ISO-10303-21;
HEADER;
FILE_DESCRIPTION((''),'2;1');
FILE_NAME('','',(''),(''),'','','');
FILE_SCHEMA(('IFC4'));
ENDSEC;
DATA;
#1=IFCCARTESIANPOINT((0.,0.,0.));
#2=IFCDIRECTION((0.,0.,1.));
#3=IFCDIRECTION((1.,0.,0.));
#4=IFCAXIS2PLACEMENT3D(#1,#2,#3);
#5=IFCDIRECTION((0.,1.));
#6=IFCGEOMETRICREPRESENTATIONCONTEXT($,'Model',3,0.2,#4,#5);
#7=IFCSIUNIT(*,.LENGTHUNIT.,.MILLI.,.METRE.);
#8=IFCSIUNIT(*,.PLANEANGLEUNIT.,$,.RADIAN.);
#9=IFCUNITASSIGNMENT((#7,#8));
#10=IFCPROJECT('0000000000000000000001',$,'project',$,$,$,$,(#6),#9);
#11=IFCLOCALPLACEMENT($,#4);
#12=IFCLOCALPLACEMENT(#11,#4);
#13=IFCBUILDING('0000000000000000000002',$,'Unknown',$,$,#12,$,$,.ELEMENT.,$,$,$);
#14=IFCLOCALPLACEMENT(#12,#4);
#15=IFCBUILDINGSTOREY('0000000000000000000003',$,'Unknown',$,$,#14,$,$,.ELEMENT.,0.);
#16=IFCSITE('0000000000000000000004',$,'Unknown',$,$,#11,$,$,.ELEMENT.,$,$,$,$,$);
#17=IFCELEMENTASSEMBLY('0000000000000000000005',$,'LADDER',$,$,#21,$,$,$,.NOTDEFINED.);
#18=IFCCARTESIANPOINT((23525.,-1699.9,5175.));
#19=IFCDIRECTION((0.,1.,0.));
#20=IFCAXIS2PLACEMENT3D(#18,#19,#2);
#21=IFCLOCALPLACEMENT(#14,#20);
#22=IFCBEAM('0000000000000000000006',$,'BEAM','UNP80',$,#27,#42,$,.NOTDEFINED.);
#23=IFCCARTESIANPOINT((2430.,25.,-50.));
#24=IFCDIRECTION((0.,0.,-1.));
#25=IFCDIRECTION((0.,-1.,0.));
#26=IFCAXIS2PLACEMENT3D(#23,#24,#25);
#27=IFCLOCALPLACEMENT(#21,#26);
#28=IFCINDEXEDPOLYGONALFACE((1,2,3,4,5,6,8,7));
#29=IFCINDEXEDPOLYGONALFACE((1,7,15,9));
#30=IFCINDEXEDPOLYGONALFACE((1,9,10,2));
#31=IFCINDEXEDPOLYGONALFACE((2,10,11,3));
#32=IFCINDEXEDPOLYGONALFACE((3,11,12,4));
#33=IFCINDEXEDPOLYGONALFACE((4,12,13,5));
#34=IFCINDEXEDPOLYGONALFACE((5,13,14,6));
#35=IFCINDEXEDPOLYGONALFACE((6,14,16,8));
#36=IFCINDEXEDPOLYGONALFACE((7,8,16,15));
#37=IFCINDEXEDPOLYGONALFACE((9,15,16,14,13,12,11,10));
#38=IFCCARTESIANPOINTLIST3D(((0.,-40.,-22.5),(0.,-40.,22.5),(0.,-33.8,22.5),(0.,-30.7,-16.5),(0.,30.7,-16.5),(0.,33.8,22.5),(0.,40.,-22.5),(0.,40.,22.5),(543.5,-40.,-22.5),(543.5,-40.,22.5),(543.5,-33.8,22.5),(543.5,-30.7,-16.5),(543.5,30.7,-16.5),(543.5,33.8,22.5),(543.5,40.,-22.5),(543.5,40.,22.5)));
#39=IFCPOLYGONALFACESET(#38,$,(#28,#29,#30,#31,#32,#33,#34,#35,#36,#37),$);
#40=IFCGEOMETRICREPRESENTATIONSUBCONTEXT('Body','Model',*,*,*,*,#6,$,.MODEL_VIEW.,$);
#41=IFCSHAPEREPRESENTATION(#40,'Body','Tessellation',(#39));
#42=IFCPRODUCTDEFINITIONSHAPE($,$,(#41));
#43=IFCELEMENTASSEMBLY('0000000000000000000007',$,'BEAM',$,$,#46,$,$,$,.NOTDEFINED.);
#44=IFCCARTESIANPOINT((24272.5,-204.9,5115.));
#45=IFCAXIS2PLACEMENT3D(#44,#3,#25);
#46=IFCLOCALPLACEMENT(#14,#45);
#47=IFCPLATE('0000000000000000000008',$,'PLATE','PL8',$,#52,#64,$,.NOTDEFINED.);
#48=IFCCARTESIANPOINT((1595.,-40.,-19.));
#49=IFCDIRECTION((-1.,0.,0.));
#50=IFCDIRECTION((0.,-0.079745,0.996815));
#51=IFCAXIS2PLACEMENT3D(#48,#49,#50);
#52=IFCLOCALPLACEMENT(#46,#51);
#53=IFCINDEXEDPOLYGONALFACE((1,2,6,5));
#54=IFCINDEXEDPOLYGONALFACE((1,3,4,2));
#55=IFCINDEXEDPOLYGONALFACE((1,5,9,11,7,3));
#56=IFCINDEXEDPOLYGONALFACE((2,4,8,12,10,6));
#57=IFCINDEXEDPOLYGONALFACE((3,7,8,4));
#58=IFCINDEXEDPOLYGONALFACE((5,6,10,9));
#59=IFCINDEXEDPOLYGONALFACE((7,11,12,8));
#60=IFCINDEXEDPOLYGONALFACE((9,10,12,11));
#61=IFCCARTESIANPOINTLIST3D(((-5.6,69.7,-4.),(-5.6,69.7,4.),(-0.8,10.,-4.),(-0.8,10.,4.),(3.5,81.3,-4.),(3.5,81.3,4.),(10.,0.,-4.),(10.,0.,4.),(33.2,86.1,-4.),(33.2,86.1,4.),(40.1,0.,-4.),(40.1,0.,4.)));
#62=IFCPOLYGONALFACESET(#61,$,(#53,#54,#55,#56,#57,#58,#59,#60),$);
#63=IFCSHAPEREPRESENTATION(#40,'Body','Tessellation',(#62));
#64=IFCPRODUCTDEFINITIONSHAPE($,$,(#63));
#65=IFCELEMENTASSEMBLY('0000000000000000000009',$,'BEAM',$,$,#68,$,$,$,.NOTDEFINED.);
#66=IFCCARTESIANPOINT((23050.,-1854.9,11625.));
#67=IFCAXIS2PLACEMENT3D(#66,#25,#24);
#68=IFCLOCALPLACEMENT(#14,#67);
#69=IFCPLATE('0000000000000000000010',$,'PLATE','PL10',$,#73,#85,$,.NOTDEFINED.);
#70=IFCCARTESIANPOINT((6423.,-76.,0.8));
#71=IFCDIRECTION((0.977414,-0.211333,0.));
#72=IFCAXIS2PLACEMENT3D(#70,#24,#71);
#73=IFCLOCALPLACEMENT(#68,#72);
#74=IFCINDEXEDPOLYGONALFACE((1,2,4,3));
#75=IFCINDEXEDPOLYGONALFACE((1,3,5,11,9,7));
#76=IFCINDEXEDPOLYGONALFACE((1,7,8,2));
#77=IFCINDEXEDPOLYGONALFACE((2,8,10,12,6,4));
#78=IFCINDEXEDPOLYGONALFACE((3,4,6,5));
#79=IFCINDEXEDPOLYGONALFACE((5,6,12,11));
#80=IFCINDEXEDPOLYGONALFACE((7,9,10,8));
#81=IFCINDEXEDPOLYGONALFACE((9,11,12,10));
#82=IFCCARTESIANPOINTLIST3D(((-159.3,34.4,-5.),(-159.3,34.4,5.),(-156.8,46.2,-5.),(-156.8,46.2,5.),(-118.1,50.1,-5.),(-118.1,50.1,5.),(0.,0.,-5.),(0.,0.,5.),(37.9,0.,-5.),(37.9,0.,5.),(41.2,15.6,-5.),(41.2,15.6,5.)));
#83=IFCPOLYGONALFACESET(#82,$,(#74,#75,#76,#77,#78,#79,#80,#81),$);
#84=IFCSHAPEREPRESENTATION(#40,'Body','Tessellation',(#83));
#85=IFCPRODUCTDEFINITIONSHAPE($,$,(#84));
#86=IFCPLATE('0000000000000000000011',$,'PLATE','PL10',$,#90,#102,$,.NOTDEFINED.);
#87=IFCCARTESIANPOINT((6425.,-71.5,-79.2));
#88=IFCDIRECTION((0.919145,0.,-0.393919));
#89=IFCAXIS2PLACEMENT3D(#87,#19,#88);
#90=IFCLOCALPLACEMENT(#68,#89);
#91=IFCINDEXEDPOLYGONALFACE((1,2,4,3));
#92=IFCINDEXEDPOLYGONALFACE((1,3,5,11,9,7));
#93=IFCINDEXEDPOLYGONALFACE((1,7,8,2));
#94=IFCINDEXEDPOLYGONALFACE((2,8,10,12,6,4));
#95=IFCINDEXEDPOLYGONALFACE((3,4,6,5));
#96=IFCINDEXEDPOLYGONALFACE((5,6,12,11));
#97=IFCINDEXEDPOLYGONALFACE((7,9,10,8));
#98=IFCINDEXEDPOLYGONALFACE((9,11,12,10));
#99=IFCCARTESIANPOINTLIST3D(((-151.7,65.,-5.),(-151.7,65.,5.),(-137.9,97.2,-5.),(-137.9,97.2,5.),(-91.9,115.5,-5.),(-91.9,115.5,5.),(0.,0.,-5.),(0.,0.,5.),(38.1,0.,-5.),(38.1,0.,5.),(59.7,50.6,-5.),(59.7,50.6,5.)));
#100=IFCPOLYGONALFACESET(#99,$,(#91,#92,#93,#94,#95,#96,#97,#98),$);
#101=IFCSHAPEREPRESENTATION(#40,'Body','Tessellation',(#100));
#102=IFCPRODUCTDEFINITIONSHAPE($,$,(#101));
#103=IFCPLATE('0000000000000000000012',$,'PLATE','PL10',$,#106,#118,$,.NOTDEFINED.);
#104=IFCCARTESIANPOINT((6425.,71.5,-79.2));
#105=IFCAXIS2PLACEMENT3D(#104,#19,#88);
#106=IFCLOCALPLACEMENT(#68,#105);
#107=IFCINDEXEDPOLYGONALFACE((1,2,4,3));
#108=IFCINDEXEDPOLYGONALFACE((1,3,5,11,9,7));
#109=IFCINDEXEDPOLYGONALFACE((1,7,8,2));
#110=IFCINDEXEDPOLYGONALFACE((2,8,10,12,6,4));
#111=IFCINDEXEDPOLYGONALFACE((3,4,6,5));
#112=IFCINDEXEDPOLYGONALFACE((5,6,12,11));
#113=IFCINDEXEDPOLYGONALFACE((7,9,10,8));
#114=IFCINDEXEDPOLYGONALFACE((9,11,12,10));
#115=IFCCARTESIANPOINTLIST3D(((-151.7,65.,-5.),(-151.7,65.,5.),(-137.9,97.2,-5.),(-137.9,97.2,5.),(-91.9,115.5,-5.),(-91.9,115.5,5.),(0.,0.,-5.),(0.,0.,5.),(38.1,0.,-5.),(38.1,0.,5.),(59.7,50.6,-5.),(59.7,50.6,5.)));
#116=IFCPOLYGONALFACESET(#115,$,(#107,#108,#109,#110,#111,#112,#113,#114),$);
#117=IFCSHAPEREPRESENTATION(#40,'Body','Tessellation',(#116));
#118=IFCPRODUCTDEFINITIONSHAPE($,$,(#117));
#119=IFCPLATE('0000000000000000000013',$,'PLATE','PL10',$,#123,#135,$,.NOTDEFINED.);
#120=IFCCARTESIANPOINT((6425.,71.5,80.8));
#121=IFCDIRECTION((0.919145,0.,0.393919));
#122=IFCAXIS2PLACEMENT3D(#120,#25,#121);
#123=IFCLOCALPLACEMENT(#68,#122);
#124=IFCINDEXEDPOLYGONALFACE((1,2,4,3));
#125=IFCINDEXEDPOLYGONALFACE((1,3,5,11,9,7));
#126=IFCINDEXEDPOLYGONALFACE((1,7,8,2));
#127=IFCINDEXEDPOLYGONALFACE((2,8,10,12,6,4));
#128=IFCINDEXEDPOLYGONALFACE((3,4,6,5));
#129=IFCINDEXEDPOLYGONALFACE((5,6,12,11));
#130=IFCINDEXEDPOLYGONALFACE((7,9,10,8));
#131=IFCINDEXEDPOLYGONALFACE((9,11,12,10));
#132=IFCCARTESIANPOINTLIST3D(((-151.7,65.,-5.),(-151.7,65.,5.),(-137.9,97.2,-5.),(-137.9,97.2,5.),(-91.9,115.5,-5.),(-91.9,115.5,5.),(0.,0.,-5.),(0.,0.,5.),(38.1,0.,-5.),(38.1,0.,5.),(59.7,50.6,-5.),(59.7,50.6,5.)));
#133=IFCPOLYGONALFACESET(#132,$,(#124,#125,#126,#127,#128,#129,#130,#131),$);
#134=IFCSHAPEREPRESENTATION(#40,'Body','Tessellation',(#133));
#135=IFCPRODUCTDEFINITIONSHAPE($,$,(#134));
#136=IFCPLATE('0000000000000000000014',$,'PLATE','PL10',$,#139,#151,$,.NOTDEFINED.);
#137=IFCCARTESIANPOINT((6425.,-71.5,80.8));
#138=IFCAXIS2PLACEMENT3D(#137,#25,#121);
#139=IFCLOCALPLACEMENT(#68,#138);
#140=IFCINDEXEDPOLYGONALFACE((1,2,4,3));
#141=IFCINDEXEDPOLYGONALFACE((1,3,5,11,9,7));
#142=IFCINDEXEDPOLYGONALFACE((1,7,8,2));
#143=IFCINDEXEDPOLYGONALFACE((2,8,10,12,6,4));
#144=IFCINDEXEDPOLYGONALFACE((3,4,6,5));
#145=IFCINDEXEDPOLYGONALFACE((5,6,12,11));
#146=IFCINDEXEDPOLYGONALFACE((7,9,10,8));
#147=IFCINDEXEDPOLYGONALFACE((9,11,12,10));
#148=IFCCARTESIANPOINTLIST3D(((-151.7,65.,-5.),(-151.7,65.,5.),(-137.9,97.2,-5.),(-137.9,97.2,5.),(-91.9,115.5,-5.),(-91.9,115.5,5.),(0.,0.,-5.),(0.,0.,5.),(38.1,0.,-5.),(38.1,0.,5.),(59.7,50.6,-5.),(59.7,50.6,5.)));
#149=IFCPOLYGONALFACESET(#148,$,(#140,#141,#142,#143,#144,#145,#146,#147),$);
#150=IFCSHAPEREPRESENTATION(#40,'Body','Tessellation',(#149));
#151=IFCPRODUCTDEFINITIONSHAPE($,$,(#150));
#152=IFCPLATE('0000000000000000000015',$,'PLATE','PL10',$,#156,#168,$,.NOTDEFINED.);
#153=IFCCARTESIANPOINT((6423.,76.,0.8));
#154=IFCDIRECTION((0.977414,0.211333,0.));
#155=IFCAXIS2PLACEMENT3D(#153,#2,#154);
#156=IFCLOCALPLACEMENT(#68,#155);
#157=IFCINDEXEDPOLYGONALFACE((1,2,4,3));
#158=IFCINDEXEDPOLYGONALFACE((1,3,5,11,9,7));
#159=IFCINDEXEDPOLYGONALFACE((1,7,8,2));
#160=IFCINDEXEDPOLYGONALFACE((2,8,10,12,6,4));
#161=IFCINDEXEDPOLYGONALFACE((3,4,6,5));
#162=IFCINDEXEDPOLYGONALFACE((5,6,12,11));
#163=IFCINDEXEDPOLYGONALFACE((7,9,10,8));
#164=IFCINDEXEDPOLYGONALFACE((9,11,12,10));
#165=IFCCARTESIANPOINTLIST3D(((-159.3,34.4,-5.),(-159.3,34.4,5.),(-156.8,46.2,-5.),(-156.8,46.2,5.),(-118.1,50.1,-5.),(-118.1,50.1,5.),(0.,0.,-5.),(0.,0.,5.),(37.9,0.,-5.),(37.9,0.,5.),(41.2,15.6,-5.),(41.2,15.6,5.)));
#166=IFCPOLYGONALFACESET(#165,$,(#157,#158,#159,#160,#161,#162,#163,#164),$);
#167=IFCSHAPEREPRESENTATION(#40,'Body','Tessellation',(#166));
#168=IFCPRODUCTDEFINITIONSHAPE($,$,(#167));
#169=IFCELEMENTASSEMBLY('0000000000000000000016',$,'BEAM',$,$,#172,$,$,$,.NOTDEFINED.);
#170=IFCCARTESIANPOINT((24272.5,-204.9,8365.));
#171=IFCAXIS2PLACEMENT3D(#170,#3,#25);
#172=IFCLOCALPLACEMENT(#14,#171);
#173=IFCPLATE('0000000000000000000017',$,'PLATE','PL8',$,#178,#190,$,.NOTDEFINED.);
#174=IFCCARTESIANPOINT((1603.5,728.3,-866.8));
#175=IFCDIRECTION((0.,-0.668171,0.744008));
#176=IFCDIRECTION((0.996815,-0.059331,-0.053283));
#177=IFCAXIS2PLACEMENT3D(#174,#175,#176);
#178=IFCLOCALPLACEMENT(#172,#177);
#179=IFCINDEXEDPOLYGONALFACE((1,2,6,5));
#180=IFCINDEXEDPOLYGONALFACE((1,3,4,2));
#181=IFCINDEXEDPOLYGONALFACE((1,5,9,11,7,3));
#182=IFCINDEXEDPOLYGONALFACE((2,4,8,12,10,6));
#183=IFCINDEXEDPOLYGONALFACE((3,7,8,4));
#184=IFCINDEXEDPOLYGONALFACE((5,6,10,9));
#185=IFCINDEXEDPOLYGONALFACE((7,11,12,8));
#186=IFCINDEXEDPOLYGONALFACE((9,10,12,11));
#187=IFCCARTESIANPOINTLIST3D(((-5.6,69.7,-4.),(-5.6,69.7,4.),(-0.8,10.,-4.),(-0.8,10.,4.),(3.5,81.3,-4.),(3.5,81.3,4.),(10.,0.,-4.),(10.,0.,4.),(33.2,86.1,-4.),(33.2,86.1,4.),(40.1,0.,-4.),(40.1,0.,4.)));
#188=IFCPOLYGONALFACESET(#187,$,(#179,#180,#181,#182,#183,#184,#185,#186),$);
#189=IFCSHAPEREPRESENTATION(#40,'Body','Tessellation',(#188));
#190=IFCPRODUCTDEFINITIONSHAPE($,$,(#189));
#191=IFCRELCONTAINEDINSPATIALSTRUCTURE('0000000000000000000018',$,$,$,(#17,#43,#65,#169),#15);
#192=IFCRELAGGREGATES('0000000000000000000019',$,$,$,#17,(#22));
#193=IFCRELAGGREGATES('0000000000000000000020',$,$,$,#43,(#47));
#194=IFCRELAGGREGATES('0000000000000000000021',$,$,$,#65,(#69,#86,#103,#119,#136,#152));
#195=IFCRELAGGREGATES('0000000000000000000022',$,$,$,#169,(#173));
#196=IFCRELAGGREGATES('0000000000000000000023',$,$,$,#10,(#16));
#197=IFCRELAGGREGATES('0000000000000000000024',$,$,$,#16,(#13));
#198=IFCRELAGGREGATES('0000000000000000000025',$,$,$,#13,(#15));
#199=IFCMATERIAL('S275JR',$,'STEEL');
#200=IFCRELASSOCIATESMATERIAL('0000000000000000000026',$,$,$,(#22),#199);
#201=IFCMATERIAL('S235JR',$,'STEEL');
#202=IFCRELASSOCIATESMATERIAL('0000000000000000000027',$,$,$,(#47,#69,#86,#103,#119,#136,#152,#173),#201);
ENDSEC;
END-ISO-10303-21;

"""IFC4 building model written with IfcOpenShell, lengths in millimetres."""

from ifc_helpers import new_model, si_unit, direction, frame, origin_with_axes, place, context, subcontext, project, spatial, line, indexed_curve, outline, extrude, material, element, aggregate, save


model = new_model("IFC4")

# Units and contexts
model_context = context("Model", 3, precision=0.2, world=origin_with_axes(), true_north=direction((0.0, 1.0)))
body_context = subcontext(model_context, "Body", "Model", "MODEL_VIEW")
ifc_project = project(units=[si_unit("LENGTHUNIT", "METRE", prefix="MILLI"), si_unit("PLANEANGLEUNIT", "RADIAN")], contexts=[model_context])

# Site, building, storey
site_placement = place(None, origin_with_axes())
site = spatial("IfcSite", under=ifc_project, at=site_placement, Name="Unknown", CompositionType="ELEMENT")
building_placement = place(site_placement, origin_with_axes())
building = spatial("IfcBuilding", under=site, at=building_placement, Name="Unknown", CompositionType="ELEMENT")
storey_placement = place(building_placement, origin_with_axes())
storey = spatial("IfcBuildingStorey", under=building, at=storey_placement, Name="Unknown", CompositionType="ELEMENT", Elevation=0.0)

# Element assembly, beam
assembly_1_placement = place(storey_placement, frame((23525.0, -1699.9, 5175.0), z_axis=(0.0, 1.0, 0.0), x_axis=(0.0, 0.0, 1.0)))
assembly_1 = element("IfcElementAssembly", 1, at=assembly_1_placement, inside=storey, Name="LADDER", PredefinedType="NOTDEFINED")
ifc_material_1 = material(Name="S235JR", Category="STEEL")
ifc_material_2 = material(Name="S275JR", Category="STEEL")
beam_1_placement = place(assembly_1_placement, frame((2430.0, 25.0, -50.0), z_axis=(0.0, 0.0, -1.0), x_axis=(0.0, -1.0, 0.0)))
beam_1 = element("IfcBeam", 2, at=beam_1_placement, material=ifc_material_2, Name="BEAM", Description="UNP80", PredefinedType="NOTDEFINED", context=body_context, shape_type="SolidModel", body=[
    extrude(outline(indexed_curve([(-22.5, -40.0), (22.5, -40.0), (22.5, -33.8), (-16.5, -30.7), (-16.5, 30.7), (22.5, 33.8), (22.5, 40.0), (-22.5, 40.0)], segments=[line(1, 2, 3, 4, 5, 6, 7, 8, 1)])), frame((0.0, 0.0, 0.0), z_axis=(-1.0, 0.0, 0.0), x_axis=(0.0, 0.0, 1.0)), (0.0, 0.0, -1.0), 543.5),
])

aggregate(assembly_1, [beam_1])

# Element assembly, plate
assembly_2_placement = place(storey_placement, frame((24272.5, -204.9, 5115.0), z_axis=(1.0, 0.0, 0.0), x_axis=(0.0, -1.0, 0.0)))
assembly_2 = element("IfcElementAssembly", 3, at=assembly_2_placement, inside=storey, Name="BEAM", PredefinedType="NOTDEFINED")
plate_1_placement = place(assembly_2_placement, frame((1595.0, -40.0, -19.0), z_axis=(-1.0, 0.0, 0.0), x_axis=(0.0, -0.079745, 0.996815)))
plate_1 = element("IfcPlate", 4, at=plate_1_placement, material=ifc_material_1, Name="PLATE", Description="PL8", PredefinedType="NOTDEFINED", context=body_context, shape_type="SolidModel", body=[
    extrude(outline(indexed_curve([(-0.8, 10.0), (10.0, 0.0), (40.1, 0.0), (33.2, 86.1), (3.5, 81.3), (-5.6, 69.7)], segments=[line(1, 2, 3, 4, 5, 6, 1)])), frame((0.0, 0.0, 4.0), z_axis=(0.0, 0.0, 1.0), x_axis=(1.0, 0.0, 0.0)), (0.0, 0.0, -1.0), 8.0),
])
aggregate(assembly_2, [plate_1])

# Element assembly, plates
assembly_3_placement = place(storey_placement, frame((23050.0, -1854.9, 11625.0), z_axis=(0.0, -1.0, 0.0), x_axis=(0.0, 0.0, -1.0)))
assembly_3 = element("IfcElementAssembly", 5, at=assembly_3_placement, inside=storey, Name="BEAM", PredefinedType="NOTDEFINED")
plate_2_placement = place(assembly_3_placement, frame((6423.0, -76.0, 0.8), z_axis=(0.0, 0.0, -1.0), x_axis=(0.977414, -0.211333, 0.0)))
plate_2 = element("IfcPlate", 6, at=plate_2_placement, material=ifc_material_1, Name="PLATE", Description="PL10", PredefinedType="NOTDEFINED", context=body_context, shape_type="SolidModel", body=[
    extrude(outline(indexed_curve([(0.0, 0.0), (37.9, 0.0), (41.2, 15.6), (-118.1, 50.1), (-156.8, 46.2), (-159.3, 34.4)], segments=[line(1, 2, 3, 4, 5, 6, 1)])), frame((0.0, 0.0, 5.0), z_axis=(0.0, 0.0, 1.0), x_axis=(1.0, 0.0, 0.0)), (0.0, 0.0, -1.0), 10.0),
])
plate_3_placement = place(assembly_3_placement, frame((6425.0, -71.5, -79.2), z_axis=(0.0, 1.0, 0.0), x_axis=(0.919145, 0.0, -0.393919)))
plate_3 = element("IfcPlate", 7, at=plate_3_placement, material=ifc_material_1, Name="PLATE", Description="PL10", PredefinedType="NOTDEFINED", context=body_context, shape_type="SolidModel", body=[
    extrude(outline(indexed_curve([(0.0, 0.0), (38.1, 0.0), (59.7, 50.6), (-91.9, 115.5), (-137.9, 97.2), (-151.7, 65.0)], segments=[line(1, 2, 3, 4, 5, 6, 1)])), frame((0.0, 0.0, 5.0), z_axis=(0.0, 0.0, 1.0), x_axis=(1.0, 0.0, 0.0)), (0.0, 0.0, -1.0), 10.0),
])
plate_4_placement = place(assembly_3_placement, frame((6425.0, 71.5, -79.2), z_axis=(0.0, 1.0, 0.0), x_axis=(0.919145, 0.0, -0.393919)))
plate_4 = element("IfcPlate", 8, at=plate_4_placement, material=ifc_material_1, Name="PLATE", Description="PL10", PredefinedType="NOTDEFINED", context=body_context, shape_type="SolidModel", body=[
    extrude(outline(indexed_curve([(0.0, 0.0), (38.1, 0.0), (59.7, 50.6), (-91.9, 115.5), (-137.9, 97.2), (-151.7, 65.0)], segments=[line(1, 2, 3, 4, 5, 6, 1)])), frame((0.0, 0.0, 5.0), z_axis=(0.0, 0.0, 1.0), x_axis=(1.0, 0.0, 0.0)), (0.0, 0.0, -1.0), 10.0),
])
plate_5_placement = place(assembly_3_placement, frame((6425.0, 71.5, 80.8), z_axis=(0.0, -1.0, 0.0), x_axis=(0.919145, 0.0, 0.393919)))
plate_5 = element("IfcPlate", 9, at=plate_5_placement, material=ifc_material_1, Name="PLATE", Description="PL10", PredefinedType="NOTDEFINED", context=body_context, shape_type="SolidModel", body=[
    extrude(outline(indexed_curve([(0.0, 0.0), (38.1, 0.0), (59.7, 50.6), (-91.9, 115.5), (-137.9, 97.2), (-151.7, 65.0)], segments=[line(1, 2, 3, 4, 5, 6, 1)])), frame((0.0, 0.0, 5.0), z_axis=(0.0, 0.0, 1.0), x_axis=(1.0, 0.0, 0.0)), (0.0, 0.0, -1.0), 10.0),
])
plate_6_placement = place(assembly_3_placement, frame((6425.0, -71.5, 80.8), z_axis=(0.0, -1.0, 0.0), x_axis=(0.919145, 0.0, 0.393919)))
plate_6 = element("IfcPlate", 10, at=plate_6_placement, material=ifc_material_1, Name="PLATE", Description="PL10", PredefinedType="NOTDEFINED", context=body_context, shape_type="SolidModel", body=[
    extrude(outline(indexed_curve([(0.0, 0.0), (38.1, 0.0), (59.7, 50.6), (-91.9, 115.5), (-137.9, 97.2), (-151.7, 65.0)], segments=[line(1, 2, 3, 4, 5, 6, 1)])), frame((0.0, 0.0, 5.0), z_axis=(0.0, 0.0, 1.0), x_axis=(1.0, 0.0, 0.0)), (0.0, 0.0, -1.0), 10.0),
])
plate_7_placement = place(assembly_3_placement, frame((6423.0, 76.0, 0.8), z_axis=(0.0, 0.0, 1.0), x_axis=(0.977414, 0.211333, 0.0)))
plate_7 = element("IfcPlate", 11, at=plate_7_placement, material=ifc_material_1, Name="PLATE", Description="PL10", PredefinedType="NOTDEFINED", context=body_context, shape_type="SolidModel", body=[
    extrude(outline(indexed_curve([(0.0, 0.0), (37.9, 0.0), (41.2, 15.6), (-118.1, 50.1), (-156.8, 46.2), (-159.3, 34.4)], segments=[line(1, 2, 3, 4, 5, 6, 1)])), frame((0.0, 0.0, 5.0), z_axis=(0.0, 0.0, 1.0), x_axis=(1.0, 0.0, 0.0)), (0.0, 0.0, -1.0), 10.0),
])
aggregate(assembly_3, [plate_2, plate_3, plate_4, plate_5, plate_6, plate_7])

# Element assembly, plate
assembly_4_placement = place(storey_placement, frame((24272.5, -204.9, 8365.0), z_axis=(1.0, 0.0, 0.0), x_axis=(0.0, -1.0, 0.0)))
assembly_4 = element("IfcElementAssembly", 12, at=assembly_4_placement, inside=storey, Name="BEAM", PredefinedType="NOTDEFINED")
plate_8_placement = place(assembly_4_placement, frame((1603.5, 728.3, -866.8), z_axis=(0.0, -0.668171, 0.744008), x_axis=(0.996815, -0.059331, -0.053283)))
plate_8 = element("IfcPlate", 13, at=plate_8_placement, material=ifc_material_1, Name="PLATE", Description="PL8", PredefinedType="NOTDEFINED", context=body_context, shape_type="SolidModel", body=[
    extrude(outline(indexed_curve([(-0.8, 10.0), (10.0, 0.0), (40.1, 0.0), (33.2, 86.1), (3.5, 81.3), (-5.6, 69.7)], segments=[line(1, 2, 3, 4, 5, 6, 1)])), frame((0.0, 0.0, 4.0), z_axis=(0.0, 0.0, 1.0), x_axis=(1.0, 0.0, 0.0)), (0.0, 0.0, -1.0), 8.0),
])
aggregate(assembly_4, [plate_8])

save(model, "model.ifc")
